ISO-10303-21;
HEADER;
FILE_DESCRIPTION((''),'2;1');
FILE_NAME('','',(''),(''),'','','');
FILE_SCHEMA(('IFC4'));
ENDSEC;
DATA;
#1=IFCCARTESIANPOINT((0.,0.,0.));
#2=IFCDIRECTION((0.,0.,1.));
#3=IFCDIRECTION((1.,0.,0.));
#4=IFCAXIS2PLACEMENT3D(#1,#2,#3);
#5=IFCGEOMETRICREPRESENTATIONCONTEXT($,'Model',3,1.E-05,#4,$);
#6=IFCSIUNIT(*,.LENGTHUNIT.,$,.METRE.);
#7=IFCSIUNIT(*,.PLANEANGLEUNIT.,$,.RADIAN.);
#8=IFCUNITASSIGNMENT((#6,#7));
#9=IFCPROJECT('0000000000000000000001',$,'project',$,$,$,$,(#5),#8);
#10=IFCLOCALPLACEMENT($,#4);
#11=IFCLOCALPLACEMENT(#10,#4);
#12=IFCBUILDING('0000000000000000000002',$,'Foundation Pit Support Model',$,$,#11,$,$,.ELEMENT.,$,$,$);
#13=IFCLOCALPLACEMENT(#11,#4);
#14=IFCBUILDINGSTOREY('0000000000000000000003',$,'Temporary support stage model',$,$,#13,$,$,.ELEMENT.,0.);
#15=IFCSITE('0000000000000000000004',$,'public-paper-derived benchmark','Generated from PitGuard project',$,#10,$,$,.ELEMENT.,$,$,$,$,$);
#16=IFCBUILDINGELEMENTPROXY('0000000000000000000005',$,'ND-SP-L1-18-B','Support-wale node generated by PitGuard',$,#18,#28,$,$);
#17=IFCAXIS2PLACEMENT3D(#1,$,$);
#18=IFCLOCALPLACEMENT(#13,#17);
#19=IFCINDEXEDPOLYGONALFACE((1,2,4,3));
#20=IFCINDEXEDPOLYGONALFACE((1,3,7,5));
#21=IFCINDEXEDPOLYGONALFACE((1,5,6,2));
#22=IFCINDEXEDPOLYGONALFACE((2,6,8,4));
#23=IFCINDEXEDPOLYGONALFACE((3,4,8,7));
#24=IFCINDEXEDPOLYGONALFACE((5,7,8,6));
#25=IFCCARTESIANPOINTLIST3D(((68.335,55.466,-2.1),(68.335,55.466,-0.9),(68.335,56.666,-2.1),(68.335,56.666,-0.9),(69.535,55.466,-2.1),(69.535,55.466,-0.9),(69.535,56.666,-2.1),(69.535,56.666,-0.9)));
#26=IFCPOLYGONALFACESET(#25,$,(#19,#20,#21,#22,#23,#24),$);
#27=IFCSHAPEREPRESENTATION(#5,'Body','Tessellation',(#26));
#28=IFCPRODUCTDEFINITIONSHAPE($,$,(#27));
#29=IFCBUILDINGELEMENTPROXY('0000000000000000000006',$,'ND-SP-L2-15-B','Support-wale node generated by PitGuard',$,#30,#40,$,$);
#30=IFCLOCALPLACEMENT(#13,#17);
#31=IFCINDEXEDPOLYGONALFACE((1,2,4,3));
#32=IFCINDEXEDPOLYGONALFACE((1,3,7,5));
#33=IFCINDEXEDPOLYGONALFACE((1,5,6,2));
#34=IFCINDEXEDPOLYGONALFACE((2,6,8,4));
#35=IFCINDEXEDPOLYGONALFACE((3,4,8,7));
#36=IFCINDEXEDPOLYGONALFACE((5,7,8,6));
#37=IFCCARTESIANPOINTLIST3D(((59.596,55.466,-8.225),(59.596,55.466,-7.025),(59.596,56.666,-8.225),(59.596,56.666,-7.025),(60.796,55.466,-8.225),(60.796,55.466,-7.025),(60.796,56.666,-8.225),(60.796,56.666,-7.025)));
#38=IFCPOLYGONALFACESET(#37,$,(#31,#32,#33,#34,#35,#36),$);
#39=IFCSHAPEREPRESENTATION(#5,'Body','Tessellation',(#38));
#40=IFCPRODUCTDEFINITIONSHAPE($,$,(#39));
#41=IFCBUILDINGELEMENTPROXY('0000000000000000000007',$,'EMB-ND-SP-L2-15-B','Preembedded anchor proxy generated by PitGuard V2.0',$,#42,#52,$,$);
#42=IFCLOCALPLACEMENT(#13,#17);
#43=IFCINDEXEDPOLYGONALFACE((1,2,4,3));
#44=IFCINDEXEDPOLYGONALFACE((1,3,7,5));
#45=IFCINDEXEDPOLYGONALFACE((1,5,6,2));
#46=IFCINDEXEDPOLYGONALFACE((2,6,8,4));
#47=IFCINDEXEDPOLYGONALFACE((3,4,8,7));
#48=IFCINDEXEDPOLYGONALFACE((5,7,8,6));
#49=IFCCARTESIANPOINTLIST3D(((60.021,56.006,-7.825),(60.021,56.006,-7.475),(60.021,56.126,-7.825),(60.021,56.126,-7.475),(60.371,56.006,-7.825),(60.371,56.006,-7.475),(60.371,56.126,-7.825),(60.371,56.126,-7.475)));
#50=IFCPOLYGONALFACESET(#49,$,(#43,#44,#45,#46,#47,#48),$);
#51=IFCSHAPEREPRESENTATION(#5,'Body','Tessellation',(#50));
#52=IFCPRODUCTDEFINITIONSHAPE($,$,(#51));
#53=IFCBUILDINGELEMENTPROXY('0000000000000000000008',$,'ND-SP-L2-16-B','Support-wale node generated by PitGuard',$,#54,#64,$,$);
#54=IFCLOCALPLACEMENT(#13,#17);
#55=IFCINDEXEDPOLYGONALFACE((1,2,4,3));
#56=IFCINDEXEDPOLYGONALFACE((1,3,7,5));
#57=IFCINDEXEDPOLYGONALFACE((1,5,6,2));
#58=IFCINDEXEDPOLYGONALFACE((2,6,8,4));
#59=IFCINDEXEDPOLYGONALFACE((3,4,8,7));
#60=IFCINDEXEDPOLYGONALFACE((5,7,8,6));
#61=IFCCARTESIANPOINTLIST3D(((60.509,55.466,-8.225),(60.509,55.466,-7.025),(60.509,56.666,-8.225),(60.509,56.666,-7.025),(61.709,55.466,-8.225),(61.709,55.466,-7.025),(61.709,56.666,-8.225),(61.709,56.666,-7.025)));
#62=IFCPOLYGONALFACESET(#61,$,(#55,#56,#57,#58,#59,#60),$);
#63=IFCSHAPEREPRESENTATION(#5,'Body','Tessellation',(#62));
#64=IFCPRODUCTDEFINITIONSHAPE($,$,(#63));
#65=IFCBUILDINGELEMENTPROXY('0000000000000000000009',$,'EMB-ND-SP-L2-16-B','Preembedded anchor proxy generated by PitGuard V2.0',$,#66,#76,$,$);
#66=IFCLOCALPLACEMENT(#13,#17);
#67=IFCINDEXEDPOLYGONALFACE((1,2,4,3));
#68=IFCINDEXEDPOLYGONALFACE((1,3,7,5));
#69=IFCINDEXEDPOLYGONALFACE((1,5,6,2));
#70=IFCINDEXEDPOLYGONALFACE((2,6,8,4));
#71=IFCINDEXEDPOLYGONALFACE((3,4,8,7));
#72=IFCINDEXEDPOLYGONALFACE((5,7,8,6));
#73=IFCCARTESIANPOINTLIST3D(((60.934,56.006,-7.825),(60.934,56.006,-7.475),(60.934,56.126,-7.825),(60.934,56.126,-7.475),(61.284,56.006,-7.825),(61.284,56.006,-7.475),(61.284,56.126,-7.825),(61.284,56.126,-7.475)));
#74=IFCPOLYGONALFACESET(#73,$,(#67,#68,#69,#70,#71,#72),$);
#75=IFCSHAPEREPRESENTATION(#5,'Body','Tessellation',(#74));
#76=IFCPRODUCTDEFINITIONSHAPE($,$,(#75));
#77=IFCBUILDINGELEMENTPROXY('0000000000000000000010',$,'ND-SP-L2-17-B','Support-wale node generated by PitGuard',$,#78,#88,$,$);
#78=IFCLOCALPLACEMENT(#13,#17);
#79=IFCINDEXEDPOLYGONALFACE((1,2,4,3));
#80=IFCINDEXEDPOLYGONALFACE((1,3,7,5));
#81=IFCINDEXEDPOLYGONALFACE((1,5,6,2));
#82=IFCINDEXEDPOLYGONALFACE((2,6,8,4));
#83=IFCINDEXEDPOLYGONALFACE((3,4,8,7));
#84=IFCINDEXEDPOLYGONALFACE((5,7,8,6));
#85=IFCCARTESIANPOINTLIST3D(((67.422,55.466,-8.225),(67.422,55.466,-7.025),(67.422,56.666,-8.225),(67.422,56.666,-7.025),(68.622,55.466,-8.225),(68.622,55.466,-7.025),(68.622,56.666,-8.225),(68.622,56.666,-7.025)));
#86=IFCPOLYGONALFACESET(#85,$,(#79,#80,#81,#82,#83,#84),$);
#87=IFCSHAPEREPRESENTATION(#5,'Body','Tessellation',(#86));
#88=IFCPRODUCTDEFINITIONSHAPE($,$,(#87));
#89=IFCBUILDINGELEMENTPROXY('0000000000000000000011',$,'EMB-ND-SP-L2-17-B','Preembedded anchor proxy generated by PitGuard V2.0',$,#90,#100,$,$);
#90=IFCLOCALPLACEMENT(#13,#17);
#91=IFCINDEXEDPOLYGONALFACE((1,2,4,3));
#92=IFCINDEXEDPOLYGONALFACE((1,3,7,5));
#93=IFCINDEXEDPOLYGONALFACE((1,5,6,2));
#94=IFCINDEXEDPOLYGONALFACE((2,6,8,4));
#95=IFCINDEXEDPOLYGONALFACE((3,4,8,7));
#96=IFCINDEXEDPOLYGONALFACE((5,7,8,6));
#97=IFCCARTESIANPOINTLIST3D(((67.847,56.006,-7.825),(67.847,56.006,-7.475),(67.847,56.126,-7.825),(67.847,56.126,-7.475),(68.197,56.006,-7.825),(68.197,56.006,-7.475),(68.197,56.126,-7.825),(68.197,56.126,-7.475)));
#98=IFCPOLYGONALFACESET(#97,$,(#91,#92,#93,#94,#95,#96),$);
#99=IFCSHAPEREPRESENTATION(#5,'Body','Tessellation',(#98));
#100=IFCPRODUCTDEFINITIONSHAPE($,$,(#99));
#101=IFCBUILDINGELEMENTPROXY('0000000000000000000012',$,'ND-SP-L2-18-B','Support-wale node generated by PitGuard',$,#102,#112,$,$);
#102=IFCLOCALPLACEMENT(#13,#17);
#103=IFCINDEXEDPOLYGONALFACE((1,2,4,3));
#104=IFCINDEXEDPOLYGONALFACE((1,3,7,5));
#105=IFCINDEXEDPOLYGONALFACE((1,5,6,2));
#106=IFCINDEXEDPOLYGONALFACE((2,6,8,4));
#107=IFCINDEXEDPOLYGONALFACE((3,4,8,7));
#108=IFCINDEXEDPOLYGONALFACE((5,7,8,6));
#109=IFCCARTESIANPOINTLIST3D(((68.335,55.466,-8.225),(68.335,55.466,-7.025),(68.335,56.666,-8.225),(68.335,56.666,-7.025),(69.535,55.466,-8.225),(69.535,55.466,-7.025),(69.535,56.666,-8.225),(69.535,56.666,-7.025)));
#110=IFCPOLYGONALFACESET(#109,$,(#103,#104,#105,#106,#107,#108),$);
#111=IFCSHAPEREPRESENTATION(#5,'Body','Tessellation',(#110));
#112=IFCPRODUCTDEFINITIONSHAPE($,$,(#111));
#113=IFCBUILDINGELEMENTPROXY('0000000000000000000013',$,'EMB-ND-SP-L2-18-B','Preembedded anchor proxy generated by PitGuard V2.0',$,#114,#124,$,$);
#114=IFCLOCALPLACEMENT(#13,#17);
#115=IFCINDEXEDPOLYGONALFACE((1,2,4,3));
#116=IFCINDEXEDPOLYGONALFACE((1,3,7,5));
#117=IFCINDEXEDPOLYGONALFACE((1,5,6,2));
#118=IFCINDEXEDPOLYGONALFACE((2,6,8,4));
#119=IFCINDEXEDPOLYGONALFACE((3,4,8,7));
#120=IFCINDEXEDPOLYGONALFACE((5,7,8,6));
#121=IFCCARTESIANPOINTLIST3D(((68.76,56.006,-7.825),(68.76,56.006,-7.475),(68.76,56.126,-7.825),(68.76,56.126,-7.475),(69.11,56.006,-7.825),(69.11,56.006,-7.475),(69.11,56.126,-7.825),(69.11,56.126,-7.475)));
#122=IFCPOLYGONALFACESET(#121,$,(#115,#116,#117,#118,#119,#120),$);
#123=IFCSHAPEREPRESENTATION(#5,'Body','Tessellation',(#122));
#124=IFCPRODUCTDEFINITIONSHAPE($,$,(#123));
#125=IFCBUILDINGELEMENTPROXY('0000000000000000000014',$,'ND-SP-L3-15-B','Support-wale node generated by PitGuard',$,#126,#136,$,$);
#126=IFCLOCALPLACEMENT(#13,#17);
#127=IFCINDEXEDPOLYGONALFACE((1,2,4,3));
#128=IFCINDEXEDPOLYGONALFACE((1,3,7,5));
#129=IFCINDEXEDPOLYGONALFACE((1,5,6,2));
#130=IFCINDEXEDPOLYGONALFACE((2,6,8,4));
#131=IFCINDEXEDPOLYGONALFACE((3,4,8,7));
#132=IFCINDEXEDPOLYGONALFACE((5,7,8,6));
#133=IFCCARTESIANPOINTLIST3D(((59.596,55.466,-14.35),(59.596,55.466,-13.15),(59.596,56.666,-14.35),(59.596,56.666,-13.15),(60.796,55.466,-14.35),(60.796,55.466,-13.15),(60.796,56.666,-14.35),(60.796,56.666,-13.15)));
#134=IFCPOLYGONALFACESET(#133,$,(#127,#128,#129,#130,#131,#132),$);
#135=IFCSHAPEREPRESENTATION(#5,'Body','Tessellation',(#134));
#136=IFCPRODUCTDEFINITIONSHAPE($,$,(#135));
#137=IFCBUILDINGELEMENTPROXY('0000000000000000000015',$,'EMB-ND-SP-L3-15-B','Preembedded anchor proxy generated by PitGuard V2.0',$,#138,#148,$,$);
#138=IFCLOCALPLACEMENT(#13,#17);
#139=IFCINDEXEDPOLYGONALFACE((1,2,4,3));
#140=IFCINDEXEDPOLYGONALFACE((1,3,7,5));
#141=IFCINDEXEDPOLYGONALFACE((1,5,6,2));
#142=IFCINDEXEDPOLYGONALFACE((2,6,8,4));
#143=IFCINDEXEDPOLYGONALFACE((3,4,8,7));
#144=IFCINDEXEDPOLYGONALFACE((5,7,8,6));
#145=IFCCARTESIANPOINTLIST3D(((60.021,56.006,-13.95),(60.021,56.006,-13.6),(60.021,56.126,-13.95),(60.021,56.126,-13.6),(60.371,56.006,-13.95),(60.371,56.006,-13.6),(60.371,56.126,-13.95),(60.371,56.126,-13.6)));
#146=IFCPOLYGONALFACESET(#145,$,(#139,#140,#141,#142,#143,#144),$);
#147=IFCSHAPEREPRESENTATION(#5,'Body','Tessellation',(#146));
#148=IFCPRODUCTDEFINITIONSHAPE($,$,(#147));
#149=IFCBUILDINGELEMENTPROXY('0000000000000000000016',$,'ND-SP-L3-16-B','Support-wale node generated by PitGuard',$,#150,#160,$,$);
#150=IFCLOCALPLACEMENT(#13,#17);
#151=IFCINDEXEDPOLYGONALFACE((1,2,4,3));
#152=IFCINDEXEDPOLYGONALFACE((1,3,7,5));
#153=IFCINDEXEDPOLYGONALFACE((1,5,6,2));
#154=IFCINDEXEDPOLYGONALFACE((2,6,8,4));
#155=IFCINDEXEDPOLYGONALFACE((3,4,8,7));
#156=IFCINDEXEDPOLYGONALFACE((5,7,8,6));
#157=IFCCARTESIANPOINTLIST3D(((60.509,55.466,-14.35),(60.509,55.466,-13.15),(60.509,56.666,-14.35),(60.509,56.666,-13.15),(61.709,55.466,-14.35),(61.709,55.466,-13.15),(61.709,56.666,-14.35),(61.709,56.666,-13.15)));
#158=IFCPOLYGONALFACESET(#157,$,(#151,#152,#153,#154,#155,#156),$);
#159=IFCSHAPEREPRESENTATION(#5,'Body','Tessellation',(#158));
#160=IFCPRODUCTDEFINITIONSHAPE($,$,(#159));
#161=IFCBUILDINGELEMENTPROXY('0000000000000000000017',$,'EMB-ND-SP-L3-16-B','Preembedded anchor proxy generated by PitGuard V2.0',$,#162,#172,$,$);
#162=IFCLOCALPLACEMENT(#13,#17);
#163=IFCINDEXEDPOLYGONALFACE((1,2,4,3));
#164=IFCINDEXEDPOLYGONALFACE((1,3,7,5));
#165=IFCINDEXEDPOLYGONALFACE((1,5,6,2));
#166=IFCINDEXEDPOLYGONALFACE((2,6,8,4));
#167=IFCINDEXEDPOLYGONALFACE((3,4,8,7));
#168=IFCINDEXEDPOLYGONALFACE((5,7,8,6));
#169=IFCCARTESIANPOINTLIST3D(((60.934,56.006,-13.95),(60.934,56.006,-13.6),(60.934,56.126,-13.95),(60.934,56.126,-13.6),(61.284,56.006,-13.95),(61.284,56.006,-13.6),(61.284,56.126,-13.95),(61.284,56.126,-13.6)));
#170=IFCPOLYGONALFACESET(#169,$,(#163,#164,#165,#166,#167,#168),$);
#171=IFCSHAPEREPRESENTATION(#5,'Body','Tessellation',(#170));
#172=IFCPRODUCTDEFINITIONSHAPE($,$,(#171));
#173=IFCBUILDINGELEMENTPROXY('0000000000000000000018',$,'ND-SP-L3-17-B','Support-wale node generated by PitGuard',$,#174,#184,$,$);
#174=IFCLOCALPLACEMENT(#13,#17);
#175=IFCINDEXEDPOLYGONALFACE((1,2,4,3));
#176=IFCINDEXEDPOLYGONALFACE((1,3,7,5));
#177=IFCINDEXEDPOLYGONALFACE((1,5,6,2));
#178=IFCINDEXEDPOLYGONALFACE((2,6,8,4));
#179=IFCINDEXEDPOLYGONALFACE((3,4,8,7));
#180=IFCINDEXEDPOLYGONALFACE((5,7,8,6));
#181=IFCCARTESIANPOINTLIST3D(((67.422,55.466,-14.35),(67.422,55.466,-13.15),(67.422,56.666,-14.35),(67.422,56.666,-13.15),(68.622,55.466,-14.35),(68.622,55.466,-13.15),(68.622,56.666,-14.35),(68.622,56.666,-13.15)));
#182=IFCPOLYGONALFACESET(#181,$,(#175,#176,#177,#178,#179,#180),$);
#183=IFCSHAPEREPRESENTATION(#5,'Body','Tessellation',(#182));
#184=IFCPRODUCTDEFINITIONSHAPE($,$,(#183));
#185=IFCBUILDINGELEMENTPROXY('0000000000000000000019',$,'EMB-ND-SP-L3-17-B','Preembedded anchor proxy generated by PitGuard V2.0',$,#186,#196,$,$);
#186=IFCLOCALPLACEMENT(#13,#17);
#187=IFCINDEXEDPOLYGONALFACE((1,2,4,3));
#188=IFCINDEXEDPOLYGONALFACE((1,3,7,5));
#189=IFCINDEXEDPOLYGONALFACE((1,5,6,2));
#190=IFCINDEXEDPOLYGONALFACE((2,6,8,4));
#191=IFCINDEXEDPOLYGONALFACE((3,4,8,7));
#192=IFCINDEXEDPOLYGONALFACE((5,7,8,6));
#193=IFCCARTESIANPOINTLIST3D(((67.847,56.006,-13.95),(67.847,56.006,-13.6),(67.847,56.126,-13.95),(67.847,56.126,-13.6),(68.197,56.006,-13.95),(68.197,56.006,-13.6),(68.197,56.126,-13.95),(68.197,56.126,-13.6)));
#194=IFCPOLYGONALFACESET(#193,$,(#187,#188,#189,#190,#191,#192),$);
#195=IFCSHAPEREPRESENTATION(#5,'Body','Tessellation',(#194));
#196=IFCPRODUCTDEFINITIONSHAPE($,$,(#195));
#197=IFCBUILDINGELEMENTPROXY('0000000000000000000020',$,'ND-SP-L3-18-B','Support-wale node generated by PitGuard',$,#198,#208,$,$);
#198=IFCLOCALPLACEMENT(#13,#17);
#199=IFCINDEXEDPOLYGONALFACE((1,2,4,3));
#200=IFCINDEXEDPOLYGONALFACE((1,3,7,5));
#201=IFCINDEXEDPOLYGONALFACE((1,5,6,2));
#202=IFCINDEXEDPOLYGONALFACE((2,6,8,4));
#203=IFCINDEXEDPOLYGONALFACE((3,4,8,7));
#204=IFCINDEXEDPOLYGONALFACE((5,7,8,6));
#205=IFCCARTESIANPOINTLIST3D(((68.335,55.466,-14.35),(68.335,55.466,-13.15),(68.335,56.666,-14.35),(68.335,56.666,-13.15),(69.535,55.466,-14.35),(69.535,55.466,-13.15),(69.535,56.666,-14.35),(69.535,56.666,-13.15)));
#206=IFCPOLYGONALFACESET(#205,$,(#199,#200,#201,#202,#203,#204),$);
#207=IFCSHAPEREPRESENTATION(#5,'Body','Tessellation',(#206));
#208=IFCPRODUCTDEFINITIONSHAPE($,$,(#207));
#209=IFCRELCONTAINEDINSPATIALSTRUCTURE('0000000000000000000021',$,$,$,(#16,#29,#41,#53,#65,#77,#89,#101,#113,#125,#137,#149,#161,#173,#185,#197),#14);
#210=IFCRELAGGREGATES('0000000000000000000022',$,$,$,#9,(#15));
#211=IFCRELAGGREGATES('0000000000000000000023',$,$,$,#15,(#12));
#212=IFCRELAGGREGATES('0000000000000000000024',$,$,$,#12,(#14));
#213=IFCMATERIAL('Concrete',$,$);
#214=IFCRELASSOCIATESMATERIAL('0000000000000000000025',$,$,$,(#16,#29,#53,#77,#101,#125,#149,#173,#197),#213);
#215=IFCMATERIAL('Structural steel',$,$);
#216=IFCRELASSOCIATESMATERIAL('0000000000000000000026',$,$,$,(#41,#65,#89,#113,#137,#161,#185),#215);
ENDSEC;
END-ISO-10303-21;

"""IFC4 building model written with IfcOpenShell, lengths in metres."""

from ifc_helpers import new_model, si_unit, frame, origin_with_axes, origin_2d, place, context, project, spatial, rectangle, extrude, material, element, save


model = new_model("IFC4")

# Units and contexts
model_context = context("Model", 3, precision=1e-05, world=origin_with_axes())
ifc_project = project(units=[si_unit("LENGTHUNIT", "METRE"), si_unit("PLANEANGLEUNIT", "RADIAN")], contexts=[model_context])

# Site, building, storey
site_placement = place(None, origin_with_axes())
site = spatial("IfcSite", under=ifc_project, at=site_placement, Name="public-paper-derived benchmark", Description="Generated from PitGuard project", CompositionType="ELEMENT")
building_placement = place(site_placement, origin_with_axes())
building = spatial("IfcBuilding", under=site, at=building_placement, Name="Foundation Pit Support Model", CompositionType="ELEMENT")
storey_placement = place(building_placement, origin_with_axes())
storey = spatial("IfcBuildingStorey", under=building, at=storey_placement, Name="Temporary support stage model", CompositionType="ELEMENT", Elevation=0.0)

# Shared definitions
ifc_material_1 = material(Name="Structural steel")

# Building element proxies
ifc_material_2 = material(Name="Concrete")
for number, where, z_axis, x_axis, name in (
    (1, (68.935, 56.066, -2.1), (0.0, 0.0, 1.0), (1.0, 0.0, 0.0), "ND-SP-L1-18-B"),
    (2, (60.196, 56.066, -8.225), (0.0, 0.0, 1.0), (1.0, 0.0, 0.0), "ND-SP-L2-15-B"),
):
    element("IfcBuildingElementProxy", number, at=place(storey_placement, frame(where, z_axis=z_axis, x_axis=x_axis)), inside=storey, material=ifc_material_2, Name=name, Description="Support-wale node generated by PitGuard", context=model_context, shape_type="SweptSolid", body=[
        extrude(rectangle(XDim=1.2, YDim=1.2, at=origin_2d()), origin_with_axes(), (0.0, 0.0, 1.0), 1.2),
    ])
proxy_1_placement = place(storey_placement, frame((60.196, 56.066, -7.825), z_axis=(0.0, 0.0, 1.0), x_axis=(1.0, 0.0, 0.0)))
element("IfcBuildingElementProxy", 3, at=proxy_1_placement, inside=storey, material=ifc_material_1, Name="EMB-ND-SP-L2-15-B", Description="Preembedded anchor proxy generated by PitGuard V2.0", context=model_context, shape_type="SweptSolid", body=[
    extrude(rectangle(XDim=0.35, YDim=0.12, at=origin_2d()), origin_with_axes(), (0.0, 0.0, 1.0), 0.35),
])
proxy_2_placement = place(storey_placement, frame((61.109, 56.066, -8.225), z_axis=(0.0, 0.0, 1.0), x_axis=(1.0, 0.0, 0.0)))
element("IfcBuildingElementProxy", 4, at=proxy_2_placement, inside=storey, material=ifc_material_2, Name="ND-SP-L2-16-B", Description="Support-wale node generated by PitGuard", context=model_context, shape_type="SweptSolid", body=[
    extrude(rectangle(XDim=1.2, YDim=1.2, at=origin_2d()), origin_with_axes(), (0.0, 0.0, 1.0), 1.2),
])
proxy_3_placement = place(storey_placement, frame((61.109, 56.066, -7.825), z_axis=(0.0, 0.0, 1.0), x_axis=(1.0, 0.0, 0.0)))
element("IfcBuildingElementProxy", 5, at=proxy_3_placement, inside=storey, material=ifc_material_1, Name="EMB-ND-SP-L2-16-B", Description="Preembedded anchor proxy generated by PitGuard V2.0", context=model_context, shape_type="SweptSolid", body=[
    extrude(rectangle(XDim=0.35, YDim=0.12, at=origin_2d()), origin_with_axes(), (0.0, 0.0, 1.0), 0.35),
])
proxy_4_placement = place(storey_placement, frame((68.022, 56.066, -8.225), z_axis=(0.0, 0.0, 1.0), x_axis=(1.0, 0.0, 0.0)))
element("IfcBuildingElementProxy", 6, at=proxy_4_placement, inside=storey, material=ifc_material_2, Name="ND-SP-L2-17-B", Description="Support-wale node generated by PitGuard", context=model_context, shape_type="SweptSolid", body=[
    extrude(rectangle(XDim=1.2, YDim=1.2, at=origin_2d()), origin_with_axes(), (0.0, 0.0, 1.0), 1.2),
])
proxy_5_placement = place(storey_placement, frame((68.022, 56.066, -7.825), z_axis=(0.0, 0.0, 1.0), x_axis=(1.0, 0.0, 0.0)))
element("IfcBuildingElementProxy", 7, at=proxy_5_placement, inside=storey, material=ifc_material_1, Name="EMB-ND-SP-L2-17-B", Description="Preembedded anchor proxy generated by PitGuard V2.0", context=model_context, shape_type="SweptSolid", body=[
    extrude(rectangle(XDim=0.35, YDim=0.12, at=origin_2d()), origin_with_axes(), (0.0, 0.0, 1.0), 0.35),
])
proxy_6_placement = place(storey_placement, frame((68.935, 56.066, -8.225), z_axis=(0.0, 0.0, 1.0), x_axis=(1.0, 0.0, 0.0)))
element("IfcBuildingElementProxy", 8, at=proxy_6_placement, inside=storey, material=ifc_material_2, Name="ND-SP-L2-18-B", Description="Support-wale node generated by PitGuard", context=model_context, shape_type="SweptSolid", body=[
    extrude(rectangle(XDim=1.2, YDim=1.2, at=origin_2d()), origin_with_axes(), (0.0, 0.0, 1.0), 1.2),
])
proxy_7_placement = place(storey_placement, frame((68.935, 56.066, -7.825), z_axis=(0.0, 0.0, 1.0), x_axis=(1.0, 0.0, 0.0)))
element("IfcBuildingElementProxy", 9, at=proxy_7_placement, inside=storey, material=ifc_material_1, Name="EMB-ND-SP-L2-18-B", Description="Preembedded anchor proxy generated by PitGuard V2.0", context=model_context, shape_type="SweptSolid", body=[
    extrude(rectangle(XDim=0.35, YDim=0.12, at=origin_2d()), origin_with_axes(), (0.0, 0.0, 1.0), 0.35),
])
proxy_8_placement = place(storey_placement, frame((60.196, 56.066, -14.35), z_axis=(0.0, 0.0, 1.0), x_axis=(1.0, 0.0, 0.0)))
element("IfcBuildingElementProxy", 10, at=proxy_8_placement, inside=storey, material=ifc_material_2, Name="ND-SP-L3-15-B", Description="Support-wale node generated by PitGuard", context=model_context, shape_type="SweptSolid", body=[
    extrude(rectangle(XDim=1.2, YDim=1.2, at=origin_2d()), origin_with_axes(), (0.0, 0.0, 1.0), 1.2),
])
proxy_9_placement = place(storey_placement, frame((60.196, 56.066, -13.95), z_axis=(0.0, 0.0, 1.0), x_axis=(1.0, 0.0, 0.0)))
element("IfcBuildingElementProxy", 11, at=proxy_9_placement, inside=storey, material=ifc_material_1, Name="EMB-ND-SP-L3-15-B", Description="Preembedded anchor proxy generated by PitGuard V2.0", context=model_context, shape_type="SweptSolid", body=[
    extrude(rectangle(XDim=0.35, YDim=0.12, at=origin_2d()), origin_with_axes(), (0.0, 0.0, 1.0), 0.35),
])
proxy_10_placement = place(storey_placement, frame((61.109, 56.066, -14.35), z_axis=(0.0, 0.0, 1.0), x_axis=(1.0, 0.0, 0.0)))
element("IfcBuildingElementProxy", 12, at=proxy_10_placement, inside=storey, material=ifc_material_2, Name="ND-SP-L3-16-B", Description="Support-wale node generated by PitGuard", context=model_context, shape_type="SweptSolid", body=[
    extrude(rectangle(XDim=1.2, YDim=1.2, at=origin_2d()), origin_with_axes(), (0.0, 0.0, 1.0), 1.2),
])
proxy_11_placement = place(storey_placement, frame((61.109, 56.066, -13.95), z_axis=(0.0, 0.0, 1.0), x_axis=(1.0, 0.0, 0.0)))
element("IfcBuildingElementProxy", 13, at=proxy_11_placement, inside=storey, material=ifc_material_1, Name="EMB-ND-SP-L3-16-B", Description="Preembedded anchor proxy generated by PitGuard V2.0", context=model_context, shape_type="SweptSolid", body=[
    extrude(rectangle(XDim=0.35, YDim=0.12, at=origin_2d()), origin_with_axes(), (0.0, 0.0, 1.0), 0.35),
])
proxy_12_placement = place(storey_placement, frame((68.022, 56.066, -14.35), z_axis=(0.0, 0.0, 1.0), x_axis=(1.0, 0.0, 0.0)))
element("IfcBuildingElementProxy", 14, at=proxy_12_placement, inside=storey, material=ifc_material_2, Name="ND-SP-L3-17-B", Description="Support-wale node generated by PitGuard", context=model_context, shape_type="SweptSolid", body=[
    extrude(rectangle(XDim=1.2, YDim=1.2, at=origin_2d()), origin_with_axes(), (0.0, 0.0, 1.0), 1.2),
])
proxy_13_placement = place(storey_placement, frame((68.022, 56.066, -13.95), z_axis=(0.0, 0.0, 1.0), x_axis=(1.0, 0.0, 0.0)))
element("IfcBuildingElementProxy", 15, at=proxy_13_placement, inside=storey, material=ifc_material_1, Name="EMB-ND-SP-L3-17-B", Description="Preembedded anchor proxy generated by PitGuard V2.0", context=model_context, shape_type="SweptSolid", body=[
    extrude(rectangle(XDim=0.35, YDim=0.12, at=origin_2d()), origin_with_axes(), (0.0, 0.0, 1.0), 0.35),
])
proxy_14_placement = place(storey_placement, frame((68.935, 56.066, -14.35), z_axis=(0.0, 0.0, 1.0), x_axis=(1.0, 0.0, 0.0)))
element("IfcBuildingElementProxy", 16, at=proxy_14_placement, inside=storey, material=ifc_material_2, Name="ND-SP-L3-18-B", Description="Support-wale node generated by PitGuard", context=model_context, shape_type="SweptSolid", body=[
    extrude(rectangle(XDim=1.2, YDim=1.2, at=origin_2d()), origin_with_axes(), (0.0, 0.0, 1.0), 1.2),
])

save(model, "model.ifc")
